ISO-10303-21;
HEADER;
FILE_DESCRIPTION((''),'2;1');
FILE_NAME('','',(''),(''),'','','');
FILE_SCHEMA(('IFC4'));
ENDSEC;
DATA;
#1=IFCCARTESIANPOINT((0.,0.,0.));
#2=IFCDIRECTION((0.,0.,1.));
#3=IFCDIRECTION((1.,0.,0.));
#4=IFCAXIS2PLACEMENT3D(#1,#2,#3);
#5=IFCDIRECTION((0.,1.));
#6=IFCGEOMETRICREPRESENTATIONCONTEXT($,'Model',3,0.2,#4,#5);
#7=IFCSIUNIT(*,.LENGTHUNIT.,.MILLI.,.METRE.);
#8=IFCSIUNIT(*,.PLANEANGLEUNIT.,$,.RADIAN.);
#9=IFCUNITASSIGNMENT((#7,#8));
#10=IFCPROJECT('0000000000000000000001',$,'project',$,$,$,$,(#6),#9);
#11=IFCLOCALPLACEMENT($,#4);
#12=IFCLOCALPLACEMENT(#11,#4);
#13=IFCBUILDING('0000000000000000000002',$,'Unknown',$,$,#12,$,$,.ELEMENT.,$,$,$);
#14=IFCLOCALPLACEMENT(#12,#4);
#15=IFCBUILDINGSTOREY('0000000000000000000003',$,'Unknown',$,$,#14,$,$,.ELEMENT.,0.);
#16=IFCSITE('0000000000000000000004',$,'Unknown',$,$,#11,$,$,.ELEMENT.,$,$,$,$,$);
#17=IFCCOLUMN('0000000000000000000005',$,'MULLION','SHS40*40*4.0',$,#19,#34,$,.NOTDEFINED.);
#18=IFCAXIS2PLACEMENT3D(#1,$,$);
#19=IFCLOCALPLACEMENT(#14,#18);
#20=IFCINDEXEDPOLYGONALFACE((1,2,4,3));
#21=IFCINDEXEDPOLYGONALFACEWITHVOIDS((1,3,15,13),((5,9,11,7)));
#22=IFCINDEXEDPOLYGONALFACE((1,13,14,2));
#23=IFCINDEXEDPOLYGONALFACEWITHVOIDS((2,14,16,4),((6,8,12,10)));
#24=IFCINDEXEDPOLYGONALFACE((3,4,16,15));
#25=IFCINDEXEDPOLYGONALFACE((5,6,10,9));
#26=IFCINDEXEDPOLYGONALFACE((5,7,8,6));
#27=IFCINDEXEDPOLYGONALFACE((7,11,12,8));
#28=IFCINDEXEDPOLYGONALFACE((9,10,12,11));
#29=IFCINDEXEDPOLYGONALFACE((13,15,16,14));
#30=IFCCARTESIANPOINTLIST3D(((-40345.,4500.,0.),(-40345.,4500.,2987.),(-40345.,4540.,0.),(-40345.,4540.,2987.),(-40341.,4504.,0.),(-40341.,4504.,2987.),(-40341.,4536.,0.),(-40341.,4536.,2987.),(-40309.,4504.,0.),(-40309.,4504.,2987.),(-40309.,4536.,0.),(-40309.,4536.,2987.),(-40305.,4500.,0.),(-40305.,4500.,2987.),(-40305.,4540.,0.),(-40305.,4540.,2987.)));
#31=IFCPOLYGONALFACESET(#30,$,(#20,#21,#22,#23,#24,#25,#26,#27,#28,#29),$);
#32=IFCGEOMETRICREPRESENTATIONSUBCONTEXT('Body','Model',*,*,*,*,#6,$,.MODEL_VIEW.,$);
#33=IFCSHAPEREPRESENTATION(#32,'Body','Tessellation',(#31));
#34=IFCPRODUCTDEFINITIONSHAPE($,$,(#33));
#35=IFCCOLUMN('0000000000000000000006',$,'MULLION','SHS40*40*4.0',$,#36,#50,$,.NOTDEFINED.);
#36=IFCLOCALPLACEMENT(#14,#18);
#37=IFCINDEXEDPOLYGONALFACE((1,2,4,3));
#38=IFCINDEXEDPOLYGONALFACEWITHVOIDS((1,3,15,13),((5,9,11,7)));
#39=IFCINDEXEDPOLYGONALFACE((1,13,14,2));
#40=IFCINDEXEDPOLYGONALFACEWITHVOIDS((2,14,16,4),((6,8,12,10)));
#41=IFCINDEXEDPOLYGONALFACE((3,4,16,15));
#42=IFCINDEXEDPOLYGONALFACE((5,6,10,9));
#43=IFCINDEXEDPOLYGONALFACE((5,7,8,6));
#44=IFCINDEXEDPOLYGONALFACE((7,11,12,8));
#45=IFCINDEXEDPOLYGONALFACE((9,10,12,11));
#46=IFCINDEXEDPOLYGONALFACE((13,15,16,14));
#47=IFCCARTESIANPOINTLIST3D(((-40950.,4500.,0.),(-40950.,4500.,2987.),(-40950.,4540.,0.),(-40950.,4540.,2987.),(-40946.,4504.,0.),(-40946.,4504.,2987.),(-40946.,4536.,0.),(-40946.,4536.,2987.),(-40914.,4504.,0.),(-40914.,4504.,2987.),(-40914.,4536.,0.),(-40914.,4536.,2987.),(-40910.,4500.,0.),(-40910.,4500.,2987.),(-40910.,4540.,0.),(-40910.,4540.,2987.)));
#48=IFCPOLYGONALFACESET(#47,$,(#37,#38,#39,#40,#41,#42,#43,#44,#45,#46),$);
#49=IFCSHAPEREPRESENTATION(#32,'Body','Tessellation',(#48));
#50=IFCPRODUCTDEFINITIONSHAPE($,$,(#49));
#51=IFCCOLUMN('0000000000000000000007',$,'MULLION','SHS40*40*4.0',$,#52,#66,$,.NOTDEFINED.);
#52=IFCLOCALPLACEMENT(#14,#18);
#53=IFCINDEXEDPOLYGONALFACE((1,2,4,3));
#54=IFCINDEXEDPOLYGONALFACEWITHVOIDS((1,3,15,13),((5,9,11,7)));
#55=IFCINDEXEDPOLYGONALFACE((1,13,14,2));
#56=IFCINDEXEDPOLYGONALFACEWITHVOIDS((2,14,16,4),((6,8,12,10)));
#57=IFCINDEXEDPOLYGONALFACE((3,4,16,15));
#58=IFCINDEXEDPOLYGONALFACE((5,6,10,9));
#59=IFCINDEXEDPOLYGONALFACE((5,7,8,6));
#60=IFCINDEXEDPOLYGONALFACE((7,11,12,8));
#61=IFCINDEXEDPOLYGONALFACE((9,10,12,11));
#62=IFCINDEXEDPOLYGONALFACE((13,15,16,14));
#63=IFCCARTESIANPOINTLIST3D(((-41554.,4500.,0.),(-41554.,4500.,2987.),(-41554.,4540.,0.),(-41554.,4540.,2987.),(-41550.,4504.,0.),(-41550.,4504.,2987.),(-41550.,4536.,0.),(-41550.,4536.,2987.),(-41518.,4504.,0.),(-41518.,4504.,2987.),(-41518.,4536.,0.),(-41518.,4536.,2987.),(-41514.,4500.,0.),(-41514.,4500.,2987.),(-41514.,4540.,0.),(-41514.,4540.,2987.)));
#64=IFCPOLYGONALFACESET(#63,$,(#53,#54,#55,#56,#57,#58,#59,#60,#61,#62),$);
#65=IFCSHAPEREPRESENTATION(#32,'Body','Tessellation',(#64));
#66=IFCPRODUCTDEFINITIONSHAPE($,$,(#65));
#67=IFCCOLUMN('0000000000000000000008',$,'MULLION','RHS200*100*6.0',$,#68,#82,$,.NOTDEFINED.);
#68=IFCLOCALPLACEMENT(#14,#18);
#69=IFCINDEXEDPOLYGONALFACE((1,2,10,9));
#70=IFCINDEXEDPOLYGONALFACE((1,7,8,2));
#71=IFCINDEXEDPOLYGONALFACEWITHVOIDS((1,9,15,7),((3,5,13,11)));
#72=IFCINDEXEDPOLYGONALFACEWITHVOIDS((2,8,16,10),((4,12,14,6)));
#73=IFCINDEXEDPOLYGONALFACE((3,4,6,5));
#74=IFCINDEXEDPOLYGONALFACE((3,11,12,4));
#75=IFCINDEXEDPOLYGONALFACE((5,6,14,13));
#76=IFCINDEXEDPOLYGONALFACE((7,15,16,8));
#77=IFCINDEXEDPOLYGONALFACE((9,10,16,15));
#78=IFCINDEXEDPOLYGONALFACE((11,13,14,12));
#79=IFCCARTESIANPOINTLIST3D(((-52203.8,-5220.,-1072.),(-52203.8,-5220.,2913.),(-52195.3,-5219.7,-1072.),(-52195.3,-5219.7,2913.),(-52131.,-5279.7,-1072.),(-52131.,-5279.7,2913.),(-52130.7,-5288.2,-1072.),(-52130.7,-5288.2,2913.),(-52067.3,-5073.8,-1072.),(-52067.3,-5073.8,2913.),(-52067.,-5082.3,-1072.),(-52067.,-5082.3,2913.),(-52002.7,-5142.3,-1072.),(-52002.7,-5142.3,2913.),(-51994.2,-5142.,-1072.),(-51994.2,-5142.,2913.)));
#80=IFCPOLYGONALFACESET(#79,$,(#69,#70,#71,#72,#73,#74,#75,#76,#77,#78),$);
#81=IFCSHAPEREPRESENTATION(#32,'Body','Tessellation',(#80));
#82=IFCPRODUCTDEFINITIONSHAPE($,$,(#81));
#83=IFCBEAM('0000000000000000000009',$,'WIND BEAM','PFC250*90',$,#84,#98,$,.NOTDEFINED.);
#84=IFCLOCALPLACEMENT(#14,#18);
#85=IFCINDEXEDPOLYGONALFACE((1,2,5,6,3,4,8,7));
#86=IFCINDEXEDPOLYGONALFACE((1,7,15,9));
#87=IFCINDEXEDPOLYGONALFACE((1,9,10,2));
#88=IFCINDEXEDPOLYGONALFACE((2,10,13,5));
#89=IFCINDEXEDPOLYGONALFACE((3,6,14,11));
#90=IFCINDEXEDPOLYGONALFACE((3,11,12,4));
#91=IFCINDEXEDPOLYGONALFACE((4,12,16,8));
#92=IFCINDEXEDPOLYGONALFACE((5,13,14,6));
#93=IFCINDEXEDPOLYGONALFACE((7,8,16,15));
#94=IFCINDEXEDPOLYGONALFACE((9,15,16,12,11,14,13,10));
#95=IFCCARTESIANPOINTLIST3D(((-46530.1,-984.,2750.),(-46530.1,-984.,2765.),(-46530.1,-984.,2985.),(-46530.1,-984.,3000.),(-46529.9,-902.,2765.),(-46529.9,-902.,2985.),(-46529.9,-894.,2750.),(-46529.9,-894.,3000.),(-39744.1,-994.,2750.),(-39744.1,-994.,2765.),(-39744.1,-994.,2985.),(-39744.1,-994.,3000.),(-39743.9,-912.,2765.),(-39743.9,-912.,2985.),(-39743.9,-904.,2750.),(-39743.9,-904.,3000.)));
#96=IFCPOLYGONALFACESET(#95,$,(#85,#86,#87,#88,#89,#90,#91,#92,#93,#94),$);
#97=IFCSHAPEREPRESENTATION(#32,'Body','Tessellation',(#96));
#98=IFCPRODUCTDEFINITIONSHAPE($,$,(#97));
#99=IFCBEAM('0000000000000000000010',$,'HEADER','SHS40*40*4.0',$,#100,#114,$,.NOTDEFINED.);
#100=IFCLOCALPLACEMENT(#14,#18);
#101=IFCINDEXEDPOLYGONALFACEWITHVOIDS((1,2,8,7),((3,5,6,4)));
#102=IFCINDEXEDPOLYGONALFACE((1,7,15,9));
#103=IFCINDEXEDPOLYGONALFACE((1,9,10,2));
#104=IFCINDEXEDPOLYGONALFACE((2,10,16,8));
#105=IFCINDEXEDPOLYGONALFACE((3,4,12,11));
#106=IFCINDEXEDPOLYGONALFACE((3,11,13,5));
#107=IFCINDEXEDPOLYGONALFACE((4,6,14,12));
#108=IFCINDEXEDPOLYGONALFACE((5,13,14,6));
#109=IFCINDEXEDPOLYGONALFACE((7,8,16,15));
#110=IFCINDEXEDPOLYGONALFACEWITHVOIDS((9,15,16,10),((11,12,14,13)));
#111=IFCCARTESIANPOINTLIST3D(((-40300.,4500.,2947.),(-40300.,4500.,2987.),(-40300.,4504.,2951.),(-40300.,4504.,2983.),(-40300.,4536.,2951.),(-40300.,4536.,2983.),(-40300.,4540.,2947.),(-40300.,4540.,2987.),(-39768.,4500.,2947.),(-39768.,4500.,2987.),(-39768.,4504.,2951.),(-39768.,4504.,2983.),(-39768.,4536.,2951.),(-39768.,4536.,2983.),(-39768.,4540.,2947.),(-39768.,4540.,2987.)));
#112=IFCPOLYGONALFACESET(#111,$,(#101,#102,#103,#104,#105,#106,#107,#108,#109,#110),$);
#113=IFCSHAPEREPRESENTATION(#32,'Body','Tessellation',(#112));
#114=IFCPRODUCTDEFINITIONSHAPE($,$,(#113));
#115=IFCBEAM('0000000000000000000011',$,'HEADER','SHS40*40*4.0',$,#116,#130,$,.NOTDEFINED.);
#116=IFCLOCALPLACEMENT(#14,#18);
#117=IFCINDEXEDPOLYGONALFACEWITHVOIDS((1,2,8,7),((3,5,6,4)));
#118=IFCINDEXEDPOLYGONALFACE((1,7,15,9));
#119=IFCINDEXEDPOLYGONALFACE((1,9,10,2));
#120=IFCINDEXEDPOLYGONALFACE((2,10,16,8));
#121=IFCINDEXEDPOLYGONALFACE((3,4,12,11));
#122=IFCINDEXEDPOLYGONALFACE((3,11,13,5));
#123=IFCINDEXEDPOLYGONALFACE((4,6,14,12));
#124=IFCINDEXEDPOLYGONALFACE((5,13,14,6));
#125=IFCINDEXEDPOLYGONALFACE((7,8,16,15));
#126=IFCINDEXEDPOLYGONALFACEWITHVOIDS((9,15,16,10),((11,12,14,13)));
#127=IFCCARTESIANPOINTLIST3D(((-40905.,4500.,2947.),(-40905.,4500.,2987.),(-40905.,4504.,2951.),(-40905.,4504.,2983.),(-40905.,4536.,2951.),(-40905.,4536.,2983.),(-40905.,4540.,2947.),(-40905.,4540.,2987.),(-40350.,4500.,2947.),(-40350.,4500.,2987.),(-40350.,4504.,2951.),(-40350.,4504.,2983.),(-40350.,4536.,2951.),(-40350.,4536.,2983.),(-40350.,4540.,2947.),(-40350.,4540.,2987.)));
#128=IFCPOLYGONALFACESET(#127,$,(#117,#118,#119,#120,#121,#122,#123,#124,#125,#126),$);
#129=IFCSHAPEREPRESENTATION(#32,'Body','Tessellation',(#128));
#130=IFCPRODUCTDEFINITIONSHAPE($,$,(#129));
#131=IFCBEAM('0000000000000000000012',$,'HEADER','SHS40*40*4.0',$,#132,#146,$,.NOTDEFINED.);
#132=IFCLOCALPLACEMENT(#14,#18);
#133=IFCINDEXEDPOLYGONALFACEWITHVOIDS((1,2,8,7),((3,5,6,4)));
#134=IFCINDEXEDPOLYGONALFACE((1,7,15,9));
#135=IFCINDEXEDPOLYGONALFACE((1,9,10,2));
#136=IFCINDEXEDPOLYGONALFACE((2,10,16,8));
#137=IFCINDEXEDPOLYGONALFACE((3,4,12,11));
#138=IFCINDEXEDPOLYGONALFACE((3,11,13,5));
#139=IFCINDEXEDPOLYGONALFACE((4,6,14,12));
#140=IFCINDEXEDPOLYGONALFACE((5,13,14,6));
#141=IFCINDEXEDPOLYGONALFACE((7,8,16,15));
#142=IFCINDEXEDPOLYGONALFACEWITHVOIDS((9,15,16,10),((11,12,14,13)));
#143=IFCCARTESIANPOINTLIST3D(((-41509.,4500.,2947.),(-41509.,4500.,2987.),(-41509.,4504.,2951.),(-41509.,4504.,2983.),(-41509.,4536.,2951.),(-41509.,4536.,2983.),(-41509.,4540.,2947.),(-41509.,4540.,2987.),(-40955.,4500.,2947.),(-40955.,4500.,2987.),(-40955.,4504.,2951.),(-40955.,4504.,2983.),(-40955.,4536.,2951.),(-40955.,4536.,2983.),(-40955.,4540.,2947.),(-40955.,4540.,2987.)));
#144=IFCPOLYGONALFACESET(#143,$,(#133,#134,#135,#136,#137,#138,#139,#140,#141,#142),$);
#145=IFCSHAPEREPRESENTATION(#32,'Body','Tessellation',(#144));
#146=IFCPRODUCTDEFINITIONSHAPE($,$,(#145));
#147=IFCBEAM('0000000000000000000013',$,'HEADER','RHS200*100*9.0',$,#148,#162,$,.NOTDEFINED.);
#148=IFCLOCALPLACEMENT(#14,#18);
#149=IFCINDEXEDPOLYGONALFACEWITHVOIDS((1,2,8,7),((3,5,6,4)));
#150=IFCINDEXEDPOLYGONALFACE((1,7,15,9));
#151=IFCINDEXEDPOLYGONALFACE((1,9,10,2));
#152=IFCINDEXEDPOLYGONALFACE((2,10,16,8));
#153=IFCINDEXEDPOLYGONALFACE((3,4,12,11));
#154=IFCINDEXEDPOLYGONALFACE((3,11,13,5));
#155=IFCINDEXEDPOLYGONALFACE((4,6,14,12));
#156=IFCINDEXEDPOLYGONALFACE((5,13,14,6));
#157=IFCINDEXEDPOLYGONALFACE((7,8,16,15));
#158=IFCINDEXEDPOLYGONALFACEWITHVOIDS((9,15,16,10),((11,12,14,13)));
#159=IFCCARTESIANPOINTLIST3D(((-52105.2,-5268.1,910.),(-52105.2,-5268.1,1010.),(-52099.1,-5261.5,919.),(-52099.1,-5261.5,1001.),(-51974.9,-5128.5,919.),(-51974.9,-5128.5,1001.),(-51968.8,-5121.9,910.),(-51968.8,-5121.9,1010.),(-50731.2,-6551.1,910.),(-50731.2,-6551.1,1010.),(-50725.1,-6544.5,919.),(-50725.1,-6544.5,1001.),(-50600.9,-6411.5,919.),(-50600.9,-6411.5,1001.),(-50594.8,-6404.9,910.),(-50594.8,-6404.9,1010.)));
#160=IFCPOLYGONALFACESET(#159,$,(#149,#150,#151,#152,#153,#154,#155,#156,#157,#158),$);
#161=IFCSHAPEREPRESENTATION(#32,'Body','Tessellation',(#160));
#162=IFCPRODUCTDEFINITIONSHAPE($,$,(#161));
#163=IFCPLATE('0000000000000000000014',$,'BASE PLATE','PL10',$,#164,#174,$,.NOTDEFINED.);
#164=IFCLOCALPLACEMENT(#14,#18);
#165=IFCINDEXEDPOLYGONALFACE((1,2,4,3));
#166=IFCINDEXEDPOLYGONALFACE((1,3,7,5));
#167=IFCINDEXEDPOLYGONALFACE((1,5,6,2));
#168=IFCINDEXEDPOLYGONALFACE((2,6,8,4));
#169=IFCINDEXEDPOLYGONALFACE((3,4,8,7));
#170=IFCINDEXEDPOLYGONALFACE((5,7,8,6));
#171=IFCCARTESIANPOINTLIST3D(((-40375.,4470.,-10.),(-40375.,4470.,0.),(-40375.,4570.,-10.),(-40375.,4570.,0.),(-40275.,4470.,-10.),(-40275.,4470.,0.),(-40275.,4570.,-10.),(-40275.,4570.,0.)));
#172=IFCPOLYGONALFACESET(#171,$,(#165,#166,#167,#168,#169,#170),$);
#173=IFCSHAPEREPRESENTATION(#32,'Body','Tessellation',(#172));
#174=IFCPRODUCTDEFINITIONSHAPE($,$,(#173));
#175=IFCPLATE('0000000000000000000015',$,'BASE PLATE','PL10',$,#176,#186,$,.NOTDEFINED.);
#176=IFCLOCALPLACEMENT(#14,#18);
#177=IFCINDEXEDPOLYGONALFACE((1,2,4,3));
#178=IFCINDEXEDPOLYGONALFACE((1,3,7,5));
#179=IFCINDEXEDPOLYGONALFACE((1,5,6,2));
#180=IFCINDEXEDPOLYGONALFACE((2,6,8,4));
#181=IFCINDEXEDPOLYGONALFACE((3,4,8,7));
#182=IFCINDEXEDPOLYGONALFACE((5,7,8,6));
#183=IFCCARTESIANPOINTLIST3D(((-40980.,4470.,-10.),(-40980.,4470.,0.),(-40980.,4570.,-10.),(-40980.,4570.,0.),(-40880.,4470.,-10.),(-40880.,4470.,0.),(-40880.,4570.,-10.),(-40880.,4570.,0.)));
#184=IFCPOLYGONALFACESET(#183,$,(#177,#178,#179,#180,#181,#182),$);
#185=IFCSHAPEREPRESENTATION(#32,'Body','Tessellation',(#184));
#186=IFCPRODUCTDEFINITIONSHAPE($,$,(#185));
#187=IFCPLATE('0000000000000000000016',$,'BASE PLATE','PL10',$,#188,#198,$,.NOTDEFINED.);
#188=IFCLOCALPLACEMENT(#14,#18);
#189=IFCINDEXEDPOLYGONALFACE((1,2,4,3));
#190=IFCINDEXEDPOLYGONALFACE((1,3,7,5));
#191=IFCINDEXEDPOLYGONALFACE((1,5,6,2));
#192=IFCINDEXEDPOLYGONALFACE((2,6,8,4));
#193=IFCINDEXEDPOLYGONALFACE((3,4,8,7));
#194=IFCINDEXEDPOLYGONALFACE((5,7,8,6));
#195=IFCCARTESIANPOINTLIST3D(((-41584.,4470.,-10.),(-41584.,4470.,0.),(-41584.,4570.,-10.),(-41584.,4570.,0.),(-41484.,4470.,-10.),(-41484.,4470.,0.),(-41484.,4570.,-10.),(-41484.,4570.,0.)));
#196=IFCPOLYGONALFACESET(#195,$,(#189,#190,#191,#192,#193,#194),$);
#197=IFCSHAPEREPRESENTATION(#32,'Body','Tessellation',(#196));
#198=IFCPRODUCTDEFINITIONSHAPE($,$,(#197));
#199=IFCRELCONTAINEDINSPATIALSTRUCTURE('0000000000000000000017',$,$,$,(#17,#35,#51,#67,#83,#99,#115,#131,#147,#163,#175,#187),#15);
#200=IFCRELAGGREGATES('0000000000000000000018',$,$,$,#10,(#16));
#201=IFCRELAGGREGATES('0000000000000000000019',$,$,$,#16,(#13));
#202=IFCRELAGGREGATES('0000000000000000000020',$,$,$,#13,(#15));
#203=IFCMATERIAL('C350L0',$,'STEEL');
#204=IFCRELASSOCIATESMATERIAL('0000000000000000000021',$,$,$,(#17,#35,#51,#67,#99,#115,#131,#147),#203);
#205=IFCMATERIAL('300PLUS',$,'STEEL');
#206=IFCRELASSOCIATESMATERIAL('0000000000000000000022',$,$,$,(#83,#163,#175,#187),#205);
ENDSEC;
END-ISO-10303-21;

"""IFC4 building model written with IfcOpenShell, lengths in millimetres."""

from ifc_helpers import new_model, si_unit, direction, frame, origin_with_axes, place, context, subcontext, project, spatial, line, indexed_curve, outline, extrude, material, element, save


model = new_model("IFC4")

# Units and contexts
model_context = context("Model", 3, precision=0.2, world=origin_with_axes(), true_north=direction((0.0, 1.0)))
body_context = subcontext(model_context, "Body", "Model", "MODEL_VIEW")
ifc_project = project(units=[si_unit("LENGTHUNIT", "METRE", prefix="MILLI"), si_unit("PLANEANGLEUNIT", "RADIAN")], contexts=[model_context])

# Site, building, storey
site_placement = place(None, origin_with_axes())
site = spatial("IfcSite", under=ifc_project, at=site_placement, Name="Unknown", CompositionType="ELEMENT")
building_placement = place(site_placement, origin_with_axes())
building = spatial("IfcBuilding", under=site, at=building_placement, Name="Unknown", CompositionType="ELEMENT")
storey_placement = place(building_placement, origin_with_axes())
storey = spatial("IfcBuildingStorey", under=building, at=storey_placement, Name="Unknown", CompositionType="ELEMENT", Elevation=0.0)

# Columns
ifc_material_1 = material(Name="C350L0", Category="STEEL")
for number, where, z_axis, x_axis, name in (
    (1, (-40325.0, 4520.0, 0.0), (0.000017, -1.0, 0.0), (0.0, 0.0, 1.0), "MULLION"),
    (2, (-40930.0, 4520.0, 0.0), (0.000017, -1.0, 0.0), (0.0, 0.0, 1.0), "MULLION"),
    (3, (-41534.0, 4520.0, 0.0), (0.000017, -1.0, 0.0), (0.0, 0.0, 1.0), "MULLION"),
):
    element("IfcColumn", number, at=place(storey_placement, frame(where, z_axis=z_axis, x_axis=x_axis)), inside=storey, material=ifc_material_1, Name=name, Description="SHS40*40*4.0", PredefinedType="NOTDEFINED", context=body_context, shape_type="SolidModel", body=[
        extrude(outline(indexed_curve([(-20.0, -20.0), (20.0, -20.0), (20.0, 20.0), (-20.0, 20.0)], segments=[line(1, 2, 3, 4, 1)]), holes=[indexed_curve([(-16.0, -16.0), (-16.0, 16.0), (16.0, 16.0), (16.0, -16.0)], segments=[line(1, 2, 3, 4, 1)])]), frame((0.0, 0.0, 0.0), z_axis=(-1.0, 0.0, 0.0), x_axis=(0.0, 0.0, 1.0)), (0.0, 0.0, -1.0), 2987.0),
    ])
column_placement = place(storey_placement, frame((-52099.0, -5181.0, -1072.0), z_axis=(0.730997, -0.682381, 0.0), x_axis=(0.0, 0.0, 1.0)))
element("IfcColumn", 4, at=column_placement, inside=storey, material=ifc_material_1, Name="MULLION", Description="RHS200*100*6.0", PredefinedType="NOTDEFINED", context=body_context, shape_type="SolidModel", body=[
    extrude(outline(indexed_curve([(-50.0, -100.0), (50.0, -100.0), (50.0, 100.0), (-50.0, 100.0)], segments=[line(1, 2, 3, 4, 1)]), holes=[indexed_curve([(-44.0, -94.0), (-44.0, 94.0), (44.0, 94.0), (44.0, -94.0)], segments=[line(1, 2, 3, 4, 1)])]), frame((0.0, 0.0, 0.0), z_axis=(-1.0, 0.0, 0.0), x_axis=(0.0, 0.0, 1.0)), (0.0, 0.0, -1.0), 3985.0),
])

# Beams
ifc_material_2 = material(Name="300PLUS", Category="STEEL")
beam_1_placement = place(storey_placement, frame((-46530.0, -939.0, 2875.0), z_axis=(-0.001474, -0.999999, 0.0), x_axis=(0.999999, -0.001474, 0.0)))
element("IfcBeam", 5, at=beam_1_placement, inside=storey, material=ifc_material_2, Name="WIND BEAM", Description="PFC250*90", PredefinedType="NOTDEFINED", context=body_context, shape_type="SolidModel", body=[
    extrude(outline(indexed_curve([(-45.0, -125.0), (45.0, -125.0), (45.0, -110.0), (-37.0, -110.0), (-37.0, 110.0), (45.0, 110.0), (45.0, 125.0), (-45.0, 125.0)], segments=[line(1, 2, 3, 4, 5, 6, 7, 8, 1)])), frame((0.0, 0.0, 0.0), z_axis=(-1.0, 0.0, 0.0), x_axis=(0.0, 0.0, 1.0)), (0.0, 0.0, -1.0), 6786.0),
])
beam_2_placement = place(storey_placement, frame((-40300.0, 4520.0, 2967.0), z_axis=(0.0, 0.0, 1.0), x_axis=(1.0, 0.0, 0.0)))
element("IfcBeam", 6, at=beam_2_placement, inside=storey, material=ifc_material_1, Name="HEADER", Description="SHS40*40*4.0", PredefinedType="NOTDEFINED", context=body_context, shape_type="SolidModel", body=[
    extrude(outline(indexed_curve([(-20.0, -20.0), (20.0, -20.0), (20.0, 20.0), (-20.0, 20.0)], segments=[line(1, 2, 3, 4, 1)]), holes=[indexed_curve([(-16.0, -16.0), (-16.0, 16.0), (16.0, 16.0), (16.0, -16.0)], segments=[line(1, 2, 3, 4, 1)])]), frame((0.0, 0.0, 0.0), z_axis=(-1.0, 0.0, 0.0), x_axis=(0.0, 0.0, 1.0)), (0.0, 0.0, -1.0), 532.0),
])
beam_3_placement = place(storey_placement, frame((-40905.0, 4520.0, 2967.0), z_axis=(0.0, 0.0, 1.0), x_axis=(1.0, 0.0, 0.0)))
element("IfcBeam", 7, at=beam_3_placement, inside=storey, material=ifc_material_1, Name="HEADER", Description="SHS40*40*4.0", PredefinedType="NOTDEFINED", context=body_context, shape_type="SolidModel", body=[
    extrude(outline(indexed_curve([(-20.0, -20.0), (20.0, -20.0), (20.0, 20.0), (-20.0, 20.0)], segments=[line(1, 2, 3, 4, 1)]), holes=[indexed_curve([(-16.0, -16.0), (-16.0, 16.0), (16.0, 16.0), (16.0, -16.0)], segments=[line(1, 2, 3, 4, 1)])]), frame((0.0, 0.0, 0.0), z_axis=(-1.0, 0.0, 0.0), x_axis=(0.0, 0.0, 1.0)), (0.0, 0.0, -1.0), 555.0),
])
beam_4_placement = place(storey_placement, frame((-41509.0, 4520.0, 2967.0), z_axis=(0.0, 0.0, 1.0), x_axis=(1.0, 0.0, 0.0)))
element("IfcBeam", 8, at=beam_4_placement, inside=storey, material=ifc_material_1, Name="HEADER", Description="SHS40*40*4.0", PredefinedType="NOTDEFINED", context=body_context, shape_type="SolidModel", body=[
    extrude(outline(indexed_curve([(-20.0, -20.0), (20.0, -20.0), (20.0, 20.0), (-20.0, 20.0)], segments=[line(1, 2, 3, 4, 1)]), holes=[indexed_curve([(-16.0, -16.0), (-16.0, 16.0), (16.0, 16.0), (16.0, -16.0)], segments=[line(1, 2, 3, 4, 1)])]), frame((0.0, 0.0, 0.0), z_axis=(-1.0, 0.0, 0.0), x_axis=(0.0, 0.0, 1.0)), (0.0, 0.0, -1.0), 554.0),
])
beam_5_placement = place(storey_placement, frame((-52037.0, -5195.0, 960.0), z_axis=(0.0, 0.0, 1.0), x_axis=(0.730896, -0.682489, 0.0)))
element("IfcBeam", 9, at=beam_5_placement, inside=storey, material=ifc_material_1, Name="HEADER", Description="RHS200*100*9.0", PredefinedType="NOTDEFINED", context=body_context, shape_type="SolidModel", body=[
    extrude(outline(indexed_curve([(-50.0, -100.0), (50.0, -100.0), (50.0, 100.0), (-50.0, 100.0)], segments=[line(1, 2, 3, 4, 1)]), holes=[indexed_curve([(-41.0, -91.0), (-41.0, 91.0), (41.0, 91.0), (41.0, -91.0)], segments=[line(1, 2, 3, 4, 1)])]), frame((0.0, 0.0, 0.0), z_axis=(-1.0, 0.0, 0.0), x_axis=(0.0, 0.0, 1.0)), (0.0, 0.0, -1.0), 1879.9),
])

# Plates
for number, where, z_axis, x_axis, name in (
    (10, (-40375.0, 4470.0, -5.0), (0.0, 0.0, 1.0), (1.0, 0.0, 0.0), "BASE PLATE"),
    (11, (-40980.0, 4470.0, -5.0), (0.0, 0.0, 1.0), (1.0, 0.0, 0.0), "BASE PLATE"),
    (12, (-41584.0, 4470.0, -5.0), (0.0, 0.0, 1.0), (1.0, 0.0, 0.0), "BASE PLATE"),
):
    element("IfcPlate", number, at=place(storey_placement, frame(where, z_axis=z_axis, x_axis=x_axis)), inside=storey, material=ifc_material_2, Name=name, Description="PL10", PredefinedType="NOTDEFINED", context=body_context, shape_type="SolidModel", body=[
        extrude(outline(indexed_curve([(0.0, 0.0), (100.0, 0.0), (100.0, 100.0), (0.0, 100.0)], segments=[line(1, 2, 3, 4, 1)])), frame((0.0, 0.0, 5.0), z_axis=(0.0, 0.0, 1.0), x_axis=(1.0, 0.0, 0.0)), (0.0, 0.0, -1.0), 10.0),
    ])

save(model, "model.ifc")
